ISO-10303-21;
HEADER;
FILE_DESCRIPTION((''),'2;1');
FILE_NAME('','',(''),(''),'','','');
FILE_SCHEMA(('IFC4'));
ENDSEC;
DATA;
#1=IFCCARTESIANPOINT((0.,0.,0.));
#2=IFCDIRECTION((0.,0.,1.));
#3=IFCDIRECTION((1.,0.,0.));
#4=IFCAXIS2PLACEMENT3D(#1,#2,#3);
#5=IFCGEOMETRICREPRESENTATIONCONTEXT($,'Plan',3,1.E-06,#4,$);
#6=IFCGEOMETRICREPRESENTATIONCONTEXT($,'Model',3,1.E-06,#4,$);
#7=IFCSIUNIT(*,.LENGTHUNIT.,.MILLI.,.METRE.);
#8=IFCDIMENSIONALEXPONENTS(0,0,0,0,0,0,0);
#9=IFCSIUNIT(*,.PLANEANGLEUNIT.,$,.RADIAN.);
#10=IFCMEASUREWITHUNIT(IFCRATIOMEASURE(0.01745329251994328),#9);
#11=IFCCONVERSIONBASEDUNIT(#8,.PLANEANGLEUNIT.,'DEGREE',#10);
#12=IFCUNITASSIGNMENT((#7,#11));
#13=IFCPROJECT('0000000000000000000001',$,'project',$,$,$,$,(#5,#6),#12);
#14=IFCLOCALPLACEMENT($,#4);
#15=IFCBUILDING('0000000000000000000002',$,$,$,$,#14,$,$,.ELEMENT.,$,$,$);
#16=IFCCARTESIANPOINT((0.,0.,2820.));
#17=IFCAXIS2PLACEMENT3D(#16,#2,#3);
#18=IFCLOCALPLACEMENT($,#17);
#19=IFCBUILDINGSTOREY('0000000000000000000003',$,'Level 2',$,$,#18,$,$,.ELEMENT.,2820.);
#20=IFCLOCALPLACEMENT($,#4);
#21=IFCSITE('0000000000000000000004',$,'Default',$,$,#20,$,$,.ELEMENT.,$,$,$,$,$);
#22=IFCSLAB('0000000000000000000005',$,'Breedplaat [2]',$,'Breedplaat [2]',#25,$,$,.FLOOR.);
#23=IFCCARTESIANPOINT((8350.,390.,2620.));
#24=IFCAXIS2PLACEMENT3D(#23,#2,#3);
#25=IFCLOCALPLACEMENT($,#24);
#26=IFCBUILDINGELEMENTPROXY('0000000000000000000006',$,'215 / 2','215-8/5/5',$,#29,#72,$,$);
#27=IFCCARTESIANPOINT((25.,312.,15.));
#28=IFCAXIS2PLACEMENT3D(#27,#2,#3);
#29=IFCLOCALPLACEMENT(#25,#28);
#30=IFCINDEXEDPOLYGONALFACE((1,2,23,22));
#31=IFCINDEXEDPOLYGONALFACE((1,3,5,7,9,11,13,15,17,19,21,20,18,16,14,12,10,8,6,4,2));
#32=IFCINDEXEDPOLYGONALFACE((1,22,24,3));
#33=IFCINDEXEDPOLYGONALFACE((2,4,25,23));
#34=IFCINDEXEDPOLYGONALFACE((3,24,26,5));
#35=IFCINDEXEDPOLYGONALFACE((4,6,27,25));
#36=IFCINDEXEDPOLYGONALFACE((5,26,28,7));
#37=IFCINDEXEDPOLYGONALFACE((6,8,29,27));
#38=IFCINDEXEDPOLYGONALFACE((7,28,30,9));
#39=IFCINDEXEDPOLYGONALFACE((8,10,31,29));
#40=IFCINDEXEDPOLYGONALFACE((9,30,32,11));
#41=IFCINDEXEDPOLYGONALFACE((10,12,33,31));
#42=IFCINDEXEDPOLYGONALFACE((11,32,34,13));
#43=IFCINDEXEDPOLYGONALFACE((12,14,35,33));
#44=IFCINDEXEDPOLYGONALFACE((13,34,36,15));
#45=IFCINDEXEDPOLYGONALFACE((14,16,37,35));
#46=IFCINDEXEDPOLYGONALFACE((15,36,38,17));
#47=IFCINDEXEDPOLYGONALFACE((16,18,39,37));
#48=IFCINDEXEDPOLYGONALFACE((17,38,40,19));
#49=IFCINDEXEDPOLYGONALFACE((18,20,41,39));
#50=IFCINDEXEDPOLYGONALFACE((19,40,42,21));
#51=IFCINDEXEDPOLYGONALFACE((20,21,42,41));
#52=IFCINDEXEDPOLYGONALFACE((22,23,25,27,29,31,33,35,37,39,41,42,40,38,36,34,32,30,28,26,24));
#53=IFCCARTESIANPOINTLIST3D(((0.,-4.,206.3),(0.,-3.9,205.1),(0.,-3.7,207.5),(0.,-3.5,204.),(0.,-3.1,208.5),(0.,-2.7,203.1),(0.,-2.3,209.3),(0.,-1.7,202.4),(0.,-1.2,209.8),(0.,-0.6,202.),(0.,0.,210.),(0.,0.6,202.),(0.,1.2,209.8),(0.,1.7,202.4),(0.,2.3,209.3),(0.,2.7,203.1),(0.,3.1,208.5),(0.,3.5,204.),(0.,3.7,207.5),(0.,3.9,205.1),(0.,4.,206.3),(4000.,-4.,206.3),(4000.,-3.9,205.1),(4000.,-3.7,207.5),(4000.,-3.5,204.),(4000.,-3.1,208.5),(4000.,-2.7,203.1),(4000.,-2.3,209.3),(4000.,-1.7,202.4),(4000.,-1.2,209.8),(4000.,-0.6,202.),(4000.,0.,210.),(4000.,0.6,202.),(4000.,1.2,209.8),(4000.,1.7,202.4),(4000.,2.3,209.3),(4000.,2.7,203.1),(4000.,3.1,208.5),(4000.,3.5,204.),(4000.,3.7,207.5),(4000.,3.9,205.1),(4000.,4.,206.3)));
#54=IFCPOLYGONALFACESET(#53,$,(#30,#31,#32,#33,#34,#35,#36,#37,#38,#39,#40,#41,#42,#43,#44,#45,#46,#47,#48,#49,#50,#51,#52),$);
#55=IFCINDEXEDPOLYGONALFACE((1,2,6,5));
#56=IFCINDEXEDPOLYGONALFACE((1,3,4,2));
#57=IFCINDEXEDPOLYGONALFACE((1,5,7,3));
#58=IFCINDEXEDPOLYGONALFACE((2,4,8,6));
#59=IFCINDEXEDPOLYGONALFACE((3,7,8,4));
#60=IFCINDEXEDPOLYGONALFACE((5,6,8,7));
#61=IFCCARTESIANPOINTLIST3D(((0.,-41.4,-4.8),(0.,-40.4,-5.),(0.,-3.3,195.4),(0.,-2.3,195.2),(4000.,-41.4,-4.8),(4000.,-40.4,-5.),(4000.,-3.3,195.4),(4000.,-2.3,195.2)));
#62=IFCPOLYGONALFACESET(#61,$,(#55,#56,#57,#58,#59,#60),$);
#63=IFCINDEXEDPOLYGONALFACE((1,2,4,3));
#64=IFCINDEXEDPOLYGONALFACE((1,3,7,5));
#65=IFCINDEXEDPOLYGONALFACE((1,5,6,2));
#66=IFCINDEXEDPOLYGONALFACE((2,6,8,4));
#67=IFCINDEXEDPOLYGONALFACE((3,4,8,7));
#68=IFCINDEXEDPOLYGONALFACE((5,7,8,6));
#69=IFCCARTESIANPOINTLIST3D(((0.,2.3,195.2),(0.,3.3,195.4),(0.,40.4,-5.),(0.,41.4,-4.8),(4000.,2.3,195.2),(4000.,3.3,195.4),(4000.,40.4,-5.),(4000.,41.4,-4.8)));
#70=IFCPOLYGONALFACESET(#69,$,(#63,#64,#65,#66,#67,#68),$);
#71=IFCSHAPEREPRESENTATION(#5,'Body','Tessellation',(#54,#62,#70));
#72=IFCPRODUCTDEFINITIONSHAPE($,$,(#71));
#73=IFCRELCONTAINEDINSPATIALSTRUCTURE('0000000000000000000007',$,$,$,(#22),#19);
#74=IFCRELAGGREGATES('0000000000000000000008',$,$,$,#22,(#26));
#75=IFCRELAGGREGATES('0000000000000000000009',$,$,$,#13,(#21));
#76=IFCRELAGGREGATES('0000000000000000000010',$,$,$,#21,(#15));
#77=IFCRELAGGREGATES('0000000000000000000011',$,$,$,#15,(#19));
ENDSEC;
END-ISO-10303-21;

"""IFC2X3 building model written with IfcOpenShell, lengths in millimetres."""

from ifc_helpers import new_model, entity, si_unit, converted_unit, frame, origin_with_axes, origin_2d_with_axis, place, context, project, spatial, rectangle, circle, extrude, element, aggregate, save


model = new_model("IFC2X3")

# Units and contexts
plan_context = context("Plan", 3, precision=1e-06, world=origin_with_axes())
model_context = context("Model", 3, precision=1e-06, world=origin_with_axes())
ifc_project = project(units=[si_unit("LENGTHUNIT", "METRE", prefix="MILLI"), converted_unit("PLANEANGLEUNIT", "DEGREE", entity("IfcRatioMeasure", 0.01745329251994328), si_unit("PLANEANGLEUNIT", "RADIAN"), dimensions=[0, 0, 0, 0, 0, 0, 0])], contexts=[plan_context, model_context])

# Site, building, storey
site_placement = place(None, origin_with_axes())
site = spatial("IfcSite", under=ifc_project, at=site_placement, Name="Default", CompositionType="ELEMENT")
building_placement = place(None, origin_with_axes())
building = spatial("IfcBuilding", under=site, at=building_placement, CompositionType="ELEMENT")
storey_placement = place(None, frame((0.0, 0.0, 2820.0), z_axis=(0.0, 0.0, 1.0), x_axis=(1.0, 0.0, 0.0)))
storey = spatial("IfcBuildingStorey", under=building, at=storey_placement, Name="Level 2", CompositionType="ELEMENT", Elevation=2820.0)

# Slab, building element proxy
slab_1_placement = place(None, frame((8350.0, 390.0, 2620.0), z_axis=(0.0, 0.0, 1.0), x_axis=(1.0, 0.0, 0.0)))
slab_1 = element("IfcSlab", 1, at=slab_1_placement, inside=storey, Name="Breedplaat [2]", ObjectType="Breedplaat [2]", PredefinedType="FLOOR")
proxy_1_placement = place(slab_1_placement, frame((25.0, 312.0, 15.0), z_axis=(0.0, 0.0, 1.0), x_axis=(1.0, 0.0, 0.0)))
proxy_1 = element("IfcBuildingElementProxy", 2, at=proxy_1_placement, Name="215 / 2", Description="215-8/5/5", context=plan_context, shape_type="SweptSolid", body=[
    extrude(circle(Radius=4.0, at=origin_2d_with_axis()), frame((0.0, 0.0, 206.0), z_axis=(1.0, 0.0, 0.0), x_axis=(0.0, 0.0, 1.0)), (0.0, 0.0, 1.0), 4000.0),
    extrude(rectangle(XDim=203.8, YDim=1.0, at=origin_2d_with_axis()), frame((0.0, -21.9, 95.2), z_axis=(1.0, 0.0, 0.0), x_axis=(0.0, 0.187112, 0.982339)), (0.0, 0.0, 1.0), 4000.0),
    extrude(rectangle(XDim=203.8, YDim=1.0, at=origin_2d_with_axis()), frame((0.0, 21.9, 95.2), z_axis=(1.0, 0.0, 0.0), x_axis=(0.0, -0.187112, 0.982339)), (0.0, 0.0, 1.0), 4000.0),
])
aggregate(slab_1, [proxy_1])

save(model, "model.ifc")
